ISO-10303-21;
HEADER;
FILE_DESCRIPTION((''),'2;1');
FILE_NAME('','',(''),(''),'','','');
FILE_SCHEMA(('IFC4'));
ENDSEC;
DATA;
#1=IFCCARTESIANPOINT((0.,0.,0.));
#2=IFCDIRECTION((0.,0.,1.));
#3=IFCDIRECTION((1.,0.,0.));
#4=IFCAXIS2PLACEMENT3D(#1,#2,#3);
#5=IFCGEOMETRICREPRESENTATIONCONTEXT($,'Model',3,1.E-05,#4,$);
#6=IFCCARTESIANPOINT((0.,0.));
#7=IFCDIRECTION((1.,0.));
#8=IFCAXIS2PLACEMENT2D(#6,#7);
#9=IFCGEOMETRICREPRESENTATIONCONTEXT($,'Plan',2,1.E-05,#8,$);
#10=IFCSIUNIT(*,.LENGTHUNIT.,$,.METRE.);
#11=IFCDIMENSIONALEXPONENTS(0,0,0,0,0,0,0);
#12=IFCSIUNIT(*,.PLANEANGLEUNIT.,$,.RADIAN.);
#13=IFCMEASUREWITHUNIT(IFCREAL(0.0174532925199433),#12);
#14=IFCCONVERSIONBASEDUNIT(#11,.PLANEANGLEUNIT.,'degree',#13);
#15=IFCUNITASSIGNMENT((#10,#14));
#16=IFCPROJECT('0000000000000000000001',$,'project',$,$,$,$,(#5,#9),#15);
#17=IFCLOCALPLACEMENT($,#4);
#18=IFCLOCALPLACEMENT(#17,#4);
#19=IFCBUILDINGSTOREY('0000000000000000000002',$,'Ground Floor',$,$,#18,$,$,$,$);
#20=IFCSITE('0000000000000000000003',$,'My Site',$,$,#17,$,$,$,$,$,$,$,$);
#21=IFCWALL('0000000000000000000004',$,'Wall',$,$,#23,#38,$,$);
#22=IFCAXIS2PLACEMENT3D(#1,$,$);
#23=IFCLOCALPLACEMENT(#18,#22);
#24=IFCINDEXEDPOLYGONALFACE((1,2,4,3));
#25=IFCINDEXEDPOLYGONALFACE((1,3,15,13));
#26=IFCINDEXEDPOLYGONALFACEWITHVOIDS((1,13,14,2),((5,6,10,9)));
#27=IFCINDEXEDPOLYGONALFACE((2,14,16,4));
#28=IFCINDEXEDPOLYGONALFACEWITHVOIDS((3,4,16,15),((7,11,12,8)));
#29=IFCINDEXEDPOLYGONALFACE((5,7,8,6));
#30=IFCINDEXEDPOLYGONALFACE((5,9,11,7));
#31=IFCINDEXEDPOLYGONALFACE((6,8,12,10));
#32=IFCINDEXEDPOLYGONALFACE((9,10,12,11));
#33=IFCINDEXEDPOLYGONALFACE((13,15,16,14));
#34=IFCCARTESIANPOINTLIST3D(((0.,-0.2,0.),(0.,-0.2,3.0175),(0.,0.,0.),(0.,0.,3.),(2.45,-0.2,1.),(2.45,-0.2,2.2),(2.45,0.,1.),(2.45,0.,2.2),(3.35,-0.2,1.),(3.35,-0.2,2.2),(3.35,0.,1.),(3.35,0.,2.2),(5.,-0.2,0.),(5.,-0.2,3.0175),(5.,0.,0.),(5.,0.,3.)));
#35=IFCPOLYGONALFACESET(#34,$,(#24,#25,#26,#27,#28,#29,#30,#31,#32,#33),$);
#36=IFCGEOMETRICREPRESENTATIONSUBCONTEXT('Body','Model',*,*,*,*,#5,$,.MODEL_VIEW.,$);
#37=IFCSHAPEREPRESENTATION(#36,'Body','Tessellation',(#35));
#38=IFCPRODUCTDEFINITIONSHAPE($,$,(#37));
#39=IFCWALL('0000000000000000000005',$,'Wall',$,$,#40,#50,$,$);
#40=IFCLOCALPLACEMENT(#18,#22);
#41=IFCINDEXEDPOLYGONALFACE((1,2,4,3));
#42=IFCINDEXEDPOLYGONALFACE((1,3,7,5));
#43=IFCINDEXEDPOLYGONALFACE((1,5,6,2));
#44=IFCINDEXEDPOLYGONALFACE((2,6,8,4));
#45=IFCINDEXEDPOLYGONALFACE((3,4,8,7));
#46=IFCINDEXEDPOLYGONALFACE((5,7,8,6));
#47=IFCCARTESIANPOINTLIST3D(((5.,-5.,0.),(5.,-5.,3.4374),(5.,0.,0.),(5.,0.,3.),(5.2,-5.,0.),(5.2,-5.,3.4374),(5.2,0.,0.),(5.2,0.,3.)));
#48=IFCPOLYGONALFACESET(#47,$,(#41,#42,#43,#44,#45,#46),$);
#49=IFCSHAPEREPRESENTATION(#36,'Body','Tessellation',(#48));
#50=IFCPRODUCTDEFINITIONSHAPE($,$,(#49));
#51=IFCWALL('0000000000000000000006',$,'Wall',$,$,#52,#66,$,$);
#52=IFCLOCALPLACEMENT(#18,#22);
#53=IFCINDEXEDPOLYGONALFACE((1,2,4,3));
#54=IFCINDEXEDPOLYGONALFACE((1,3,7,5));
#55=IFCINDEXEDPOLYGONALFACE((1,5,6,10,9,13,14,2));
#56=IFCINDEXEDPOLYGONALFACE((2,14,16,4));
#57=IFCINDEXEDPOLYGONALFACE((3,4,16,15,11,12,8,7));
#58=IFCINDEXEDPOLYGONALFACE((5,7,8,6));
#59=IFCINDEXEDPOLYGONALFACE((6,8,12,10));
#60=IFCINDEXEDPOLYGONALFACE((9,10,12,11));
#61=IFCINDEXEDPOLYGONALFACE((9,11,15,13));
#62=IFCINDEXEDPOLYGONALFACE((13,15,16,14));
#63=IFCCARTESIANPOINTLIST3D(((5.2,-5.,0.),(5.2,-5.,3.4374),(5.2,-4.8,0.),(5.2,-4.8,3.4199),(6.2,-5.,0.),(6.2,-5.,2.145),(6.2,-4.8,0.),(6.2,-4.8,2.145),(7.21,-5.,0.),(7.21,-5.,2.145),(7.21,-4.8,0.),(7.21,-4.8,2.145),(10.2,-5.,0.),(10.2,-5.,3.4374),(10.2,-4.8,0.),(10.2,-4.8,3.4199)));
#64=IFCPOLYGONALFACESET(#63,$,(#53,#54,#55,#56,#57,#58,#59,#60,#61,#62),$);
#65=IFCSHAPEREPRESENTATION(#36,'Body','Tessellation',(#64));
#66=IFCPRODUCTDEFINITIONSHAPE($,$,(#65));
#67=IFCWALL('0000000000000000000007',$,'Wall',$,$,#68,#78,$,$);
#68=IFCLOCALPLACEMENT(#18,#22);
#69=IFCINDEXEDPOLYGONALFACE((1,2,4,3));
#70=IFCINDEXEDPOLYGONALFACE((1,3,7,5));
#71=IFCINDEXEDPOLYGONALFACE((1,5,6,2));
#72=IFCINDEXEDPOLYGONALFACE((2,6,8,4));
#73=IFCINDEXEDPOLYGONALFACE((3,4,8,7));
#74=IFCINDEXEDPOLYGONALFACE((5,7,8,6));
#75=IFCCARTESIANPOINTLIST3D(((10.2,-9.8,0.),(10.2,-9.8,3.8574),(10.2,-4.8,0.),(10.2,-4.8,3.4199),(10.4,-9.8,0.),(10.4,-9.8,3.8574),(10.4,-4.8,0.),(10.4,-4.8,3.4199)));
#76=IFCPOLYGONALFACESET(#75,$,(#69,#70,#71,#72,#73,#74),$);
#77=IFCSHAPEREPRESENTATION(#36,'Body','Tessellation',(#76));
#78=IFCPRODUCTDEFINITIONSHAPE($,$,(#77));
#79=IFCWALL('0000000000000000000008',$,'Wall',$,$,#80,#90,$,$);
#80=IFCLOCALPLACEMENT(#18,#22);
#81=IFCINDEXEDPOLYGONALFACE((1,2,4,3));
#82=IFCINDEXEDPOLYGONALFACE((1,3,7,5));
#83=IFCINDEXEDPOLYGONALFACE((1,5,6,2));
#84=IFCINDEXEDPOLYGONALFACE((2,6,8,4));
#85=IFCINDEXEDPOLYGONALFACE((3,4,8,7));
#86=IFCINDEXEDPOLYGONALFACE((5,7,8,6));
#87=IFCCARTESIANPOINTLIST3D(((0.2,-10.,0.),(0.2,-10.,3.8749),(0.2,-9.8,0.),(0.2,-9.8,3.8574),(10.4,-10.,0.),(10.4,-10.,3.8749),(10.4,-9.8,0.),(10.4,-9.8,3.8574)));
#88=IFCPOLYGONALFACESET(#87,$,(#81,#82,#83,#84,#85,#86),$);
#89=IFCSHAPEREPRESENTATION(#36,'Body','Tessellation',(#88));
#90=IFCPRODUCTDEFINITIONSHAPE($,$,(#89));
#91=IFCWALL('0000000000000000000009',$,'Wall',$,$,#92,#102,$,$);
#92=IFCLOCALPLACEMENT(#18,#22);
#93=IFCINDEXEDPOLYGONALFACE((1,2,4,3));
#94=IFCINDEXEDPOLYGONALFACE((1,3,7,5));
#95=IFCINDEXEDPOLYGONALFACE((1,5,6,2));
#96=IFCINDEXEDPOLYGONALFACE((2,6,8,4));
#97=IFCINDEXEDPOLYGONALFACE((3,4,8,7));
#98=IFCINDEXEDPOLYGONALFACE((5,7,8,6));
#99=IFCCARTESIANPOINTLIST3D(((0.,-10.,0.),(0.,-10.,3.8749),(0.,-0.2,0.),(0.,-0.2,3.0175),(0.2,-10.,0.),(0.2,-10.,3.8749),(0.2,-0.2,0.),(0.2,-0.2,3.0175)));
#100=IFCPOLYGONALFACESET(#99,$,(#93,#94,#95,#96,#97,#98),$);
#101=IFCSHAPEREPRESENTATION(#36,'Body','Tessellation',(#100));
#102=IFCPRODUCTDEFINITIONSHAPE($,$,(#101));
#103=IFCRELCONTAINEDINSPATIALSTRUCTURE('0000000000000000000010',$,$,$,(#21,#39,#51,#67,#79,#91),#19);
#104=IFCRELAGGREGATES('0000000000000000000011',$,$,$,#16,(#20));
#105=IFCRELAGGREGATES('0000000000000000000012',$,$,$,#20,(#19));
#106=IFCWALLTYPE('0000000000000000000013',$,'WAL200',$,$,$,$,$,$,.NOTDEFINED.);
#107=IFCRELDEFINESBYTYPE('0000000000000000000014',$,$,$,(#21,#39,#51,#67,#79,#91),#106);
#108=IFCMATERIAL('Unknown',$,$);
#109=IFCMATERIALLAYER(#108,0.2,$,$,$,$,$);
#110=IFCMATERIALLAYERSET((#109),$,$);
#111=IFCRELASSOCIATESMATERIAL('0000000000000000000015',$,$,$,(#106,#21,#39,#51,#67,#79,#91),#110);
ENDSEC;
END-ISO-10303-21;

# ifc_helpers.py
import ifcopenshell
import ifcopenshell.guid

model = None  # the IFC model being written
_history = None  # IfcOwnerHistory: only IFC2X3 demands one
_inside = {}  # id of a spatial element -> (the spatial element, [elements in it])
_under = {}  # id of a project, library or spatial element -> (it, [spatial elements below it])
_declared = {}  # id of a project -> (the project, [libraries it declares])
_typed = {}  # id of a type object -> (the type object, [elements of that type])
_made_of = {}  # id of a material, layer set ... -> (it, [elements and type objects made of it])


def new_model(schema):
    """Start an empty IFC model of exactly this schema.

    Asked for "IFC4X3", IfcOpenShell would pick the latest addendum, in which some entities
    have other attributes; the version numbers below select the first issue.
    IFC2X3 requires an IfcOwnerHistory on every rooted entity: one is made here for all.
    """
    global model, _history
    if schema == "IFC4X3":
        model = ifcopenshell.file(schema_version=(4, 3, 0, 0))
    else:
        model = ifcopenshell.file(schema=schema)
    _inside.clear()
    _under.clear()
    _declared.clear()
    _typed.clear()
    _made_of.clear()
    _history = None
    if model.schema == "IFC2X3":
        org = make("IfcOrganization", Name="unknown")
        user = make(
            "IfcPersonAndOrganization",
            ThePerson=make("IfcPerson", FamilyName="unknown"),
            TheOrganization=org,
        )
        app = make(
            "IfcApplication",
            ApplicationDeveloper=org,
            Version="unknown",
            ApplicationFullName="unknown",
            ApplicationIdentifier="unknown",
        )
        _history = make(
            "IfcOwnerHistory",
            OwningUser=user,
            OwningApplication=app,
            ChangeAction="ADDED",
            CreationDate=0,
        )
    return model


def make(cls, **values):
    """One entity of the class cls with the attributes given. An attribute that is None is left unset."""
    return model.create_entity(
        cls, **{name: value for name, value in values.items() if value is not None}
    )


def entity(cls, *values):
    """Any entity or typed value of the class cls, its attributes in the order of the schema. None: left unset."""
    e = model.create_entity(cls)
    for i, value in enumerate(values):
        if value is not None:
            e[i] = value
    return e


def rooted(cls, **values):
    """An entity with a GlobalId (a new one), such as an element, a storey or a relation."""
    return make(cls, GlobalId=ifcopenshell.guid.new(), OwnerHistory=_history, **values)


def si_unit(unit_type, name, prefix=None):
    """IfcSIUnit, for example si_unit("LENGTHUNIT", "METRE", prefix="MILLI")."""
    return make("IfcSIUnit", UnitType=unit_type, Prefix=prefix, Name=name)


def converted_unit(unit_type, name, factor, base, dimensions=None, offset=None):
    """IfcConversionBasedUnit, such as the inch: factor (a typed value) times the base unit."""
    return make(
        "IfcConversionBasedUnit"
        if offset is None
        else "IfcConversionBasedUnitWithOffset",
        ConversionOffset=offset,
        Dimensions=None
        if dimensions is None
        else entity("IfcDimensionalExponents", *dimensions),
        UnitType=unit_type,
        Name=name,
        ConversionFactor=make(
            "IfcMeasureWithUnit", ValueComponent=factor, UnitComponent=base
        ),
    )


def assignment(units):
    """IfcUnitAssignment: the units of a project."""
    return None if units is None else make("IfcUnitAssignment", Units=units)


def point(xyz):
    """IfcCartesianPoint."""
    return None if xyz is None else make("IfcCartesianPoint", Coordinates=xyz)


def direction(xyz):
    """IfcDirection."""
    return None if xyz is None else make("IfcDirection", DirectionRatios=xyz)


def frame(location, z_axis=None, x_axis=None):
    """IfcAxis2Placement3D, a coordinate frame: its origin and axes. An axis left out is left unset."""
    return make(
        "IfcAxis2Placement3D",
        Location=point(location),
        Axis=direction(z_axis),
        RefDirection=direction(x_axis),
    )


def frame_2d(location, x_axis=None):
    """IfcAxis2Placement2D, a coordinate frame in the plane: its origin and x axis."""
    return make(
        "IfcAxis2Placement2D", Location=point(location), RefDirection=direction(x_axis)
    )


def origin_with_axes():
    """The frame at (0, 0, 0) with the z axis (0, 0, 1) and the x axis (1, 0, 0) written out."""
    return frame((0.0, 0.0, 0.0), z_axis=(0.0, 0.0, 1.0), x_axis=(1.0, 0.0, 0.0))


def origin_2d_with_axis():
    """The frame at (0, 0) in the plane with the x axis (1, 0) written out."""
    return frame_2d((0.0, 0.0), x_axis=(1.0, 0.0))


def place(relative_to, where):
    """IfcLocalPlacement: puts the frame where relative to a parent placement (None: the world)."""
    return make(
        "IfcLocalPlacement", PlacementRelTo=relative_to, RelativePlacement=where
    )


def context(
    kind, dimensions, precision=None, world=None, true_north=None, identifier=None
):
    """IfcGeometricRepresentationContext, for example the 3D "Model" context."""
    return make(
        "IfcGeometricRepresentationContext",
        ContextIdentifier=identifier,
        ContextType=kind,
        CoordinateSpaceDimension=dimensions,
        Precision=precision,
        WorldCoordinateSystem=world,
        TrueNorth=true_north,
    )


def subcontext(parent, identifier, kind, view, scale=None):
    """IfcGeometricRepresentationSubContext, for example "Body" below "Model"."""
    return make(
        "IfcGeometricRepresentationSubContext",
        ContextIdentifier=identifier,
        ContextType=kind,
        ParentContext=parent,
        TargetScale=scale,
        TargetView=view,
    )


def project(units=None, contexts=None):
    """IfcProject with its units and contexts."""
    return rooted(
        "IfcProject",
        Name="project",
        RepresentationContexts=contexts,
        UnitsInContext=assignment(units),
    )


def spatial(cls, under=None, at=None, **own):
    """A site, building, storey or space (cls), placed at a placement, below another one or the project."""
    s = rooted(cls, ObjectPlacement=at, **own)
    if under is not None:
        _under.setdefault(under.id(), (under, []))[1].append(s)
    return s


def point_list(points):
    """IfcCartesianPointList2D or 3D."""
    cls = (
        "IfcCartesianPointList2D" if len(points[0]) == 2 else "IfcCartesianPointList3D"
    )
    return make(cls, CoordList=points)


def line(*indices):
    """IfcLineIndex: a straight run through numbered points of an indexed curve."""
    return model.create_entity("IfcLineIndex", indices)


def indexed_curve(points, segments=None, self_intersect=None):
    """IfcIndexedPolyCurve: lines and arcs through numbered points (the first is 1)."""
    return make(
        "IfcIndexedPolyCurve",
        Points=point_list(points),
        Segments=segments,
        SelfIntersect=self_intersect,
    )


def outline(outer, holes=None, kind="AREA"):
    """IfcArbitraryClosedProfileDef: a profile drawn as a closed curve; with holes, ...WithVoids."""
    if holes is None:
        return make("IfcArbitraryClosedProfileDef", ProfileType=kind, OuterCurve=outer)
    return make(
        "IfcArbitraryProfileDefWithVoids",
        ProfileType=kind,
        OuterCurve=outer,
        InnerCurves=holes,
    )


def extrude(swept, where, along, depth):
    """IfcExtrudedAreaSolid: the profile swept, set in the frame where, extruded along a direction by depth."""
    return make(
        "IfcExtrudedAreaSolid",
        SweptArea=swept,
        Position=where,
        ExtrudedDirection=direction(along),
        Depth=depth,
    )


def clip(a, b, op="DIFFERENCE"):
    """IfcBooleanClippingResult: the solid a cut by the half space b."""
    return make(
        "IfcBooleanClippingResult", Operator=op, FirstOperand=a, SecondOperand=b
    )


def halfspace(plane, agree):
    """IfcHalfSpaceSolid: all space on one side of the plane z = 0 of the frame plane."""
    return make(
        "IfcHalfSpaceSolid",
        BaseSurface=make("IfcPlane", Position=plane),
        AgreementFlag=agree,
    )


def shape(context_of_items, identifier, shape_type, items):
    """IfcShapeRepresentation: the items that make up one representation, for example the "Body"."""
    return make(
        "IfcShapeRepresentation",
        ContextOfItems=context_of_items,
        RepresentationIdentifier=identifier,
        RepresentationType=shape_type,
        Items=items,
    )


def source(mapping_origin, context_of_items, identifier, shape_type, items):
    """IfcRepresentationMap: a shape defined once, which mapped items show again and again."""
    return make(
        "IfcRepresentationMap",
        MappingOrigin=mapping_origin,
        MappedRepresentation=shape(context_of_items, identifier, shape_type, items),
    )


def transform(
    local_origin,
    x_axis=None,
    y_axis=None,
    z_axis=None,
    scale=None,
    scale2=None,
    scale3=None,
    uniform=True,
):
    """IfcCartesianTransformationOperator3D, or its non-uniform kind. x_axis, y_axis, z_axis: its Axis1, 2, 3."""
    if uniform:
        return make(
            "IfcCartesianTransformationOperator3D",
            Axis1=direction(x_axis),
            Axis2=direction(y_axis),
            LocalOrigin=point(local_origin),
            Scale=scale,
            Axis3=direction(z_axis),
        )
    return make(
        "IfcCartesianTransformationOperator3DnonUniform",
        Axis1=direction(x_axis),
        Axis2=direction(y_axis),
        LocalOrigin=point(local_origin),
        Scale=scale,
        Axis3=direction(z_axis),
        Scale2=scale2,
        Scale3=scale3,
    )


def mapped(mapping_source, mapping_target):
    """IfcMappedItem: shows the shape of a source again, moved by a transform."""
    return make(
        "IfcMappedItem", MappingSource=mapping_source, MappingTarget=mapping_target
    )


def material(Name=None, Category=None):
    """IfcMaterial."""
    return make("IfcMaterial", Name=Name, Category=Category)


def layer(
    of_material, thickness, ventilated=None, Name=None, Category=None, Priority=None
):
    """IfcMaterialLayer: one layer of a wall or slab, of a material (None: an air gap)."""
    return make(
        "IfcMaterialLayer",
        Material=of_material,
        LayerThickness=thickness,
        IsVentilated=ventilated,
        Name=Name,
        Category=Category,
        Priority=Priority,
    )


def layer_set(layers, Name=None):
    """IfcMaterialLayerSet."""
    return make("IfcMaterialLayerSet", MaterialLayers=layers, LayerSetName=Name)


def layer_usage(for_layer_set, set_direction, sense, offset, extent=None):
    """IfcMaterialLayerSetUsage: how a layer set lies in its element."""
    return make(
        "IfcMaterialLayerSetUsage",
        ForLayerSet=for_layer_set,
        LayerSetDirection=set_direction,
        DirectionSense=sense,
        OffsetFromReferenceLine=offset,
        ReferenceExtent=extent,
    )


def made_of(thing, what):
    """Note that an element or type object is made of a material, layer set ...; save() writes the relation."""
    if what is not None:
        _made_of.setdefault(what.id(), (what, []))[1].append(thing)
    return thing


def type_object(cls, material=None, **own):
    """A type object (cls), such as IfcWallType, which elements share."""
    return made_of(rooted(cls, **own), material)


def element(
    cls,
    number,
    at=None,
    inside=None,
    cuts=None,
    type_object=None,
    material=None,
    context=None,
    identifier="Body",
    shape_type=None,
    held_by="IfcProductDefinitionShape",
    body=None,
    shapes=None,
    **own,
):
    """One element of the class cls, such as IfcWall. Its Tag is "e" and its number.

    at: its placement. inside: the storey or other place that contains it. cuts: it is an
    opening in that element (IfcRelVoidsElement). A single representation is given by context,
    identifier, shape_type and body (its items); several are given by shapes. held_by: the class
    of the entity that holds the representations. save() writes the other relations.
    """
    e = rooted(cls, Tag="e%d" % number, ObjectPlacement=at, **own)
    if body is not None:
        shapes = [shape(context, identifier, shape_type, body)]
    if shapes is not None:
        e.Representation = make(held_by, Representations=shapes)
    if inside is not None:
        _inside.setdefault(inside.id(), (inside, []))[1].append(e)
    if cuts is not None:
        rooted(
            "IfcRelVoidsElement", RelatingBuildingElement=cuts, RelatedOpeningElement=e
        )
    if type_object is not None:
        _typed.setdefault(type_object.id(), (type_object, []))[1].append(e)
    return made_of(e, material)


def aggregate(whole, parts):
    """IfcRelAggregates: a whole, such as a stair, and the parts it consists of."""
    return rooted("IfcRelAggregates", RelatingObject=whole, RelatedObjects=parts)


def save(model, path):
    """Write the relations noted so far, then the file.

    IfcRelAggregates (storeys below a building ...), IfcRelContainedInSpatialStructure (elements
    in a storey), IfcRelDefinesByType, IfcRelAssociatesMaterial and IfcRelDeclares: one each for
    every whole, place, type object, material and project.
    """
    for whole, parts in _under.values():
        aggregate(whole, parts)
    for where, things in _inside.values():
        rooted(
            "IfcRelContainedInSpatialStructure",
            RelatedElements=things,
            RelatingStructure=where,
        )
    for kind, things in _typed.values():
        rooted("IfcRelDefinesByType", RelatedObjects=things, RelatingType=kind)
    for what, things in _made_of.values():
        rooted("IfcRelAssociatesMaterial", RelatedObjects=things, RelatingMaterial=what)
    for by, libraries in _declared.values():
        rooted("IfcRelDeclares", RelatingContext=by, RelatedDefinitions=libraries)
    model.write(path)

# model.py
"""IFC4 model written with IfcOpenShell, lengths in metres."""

from ifc_helpers import new_model, entity, si_unit, converted_unit, frame, origin_with_axes, origin_2d_with_axis, place, context, subcontext, project, spatial, line, indexed_curve, outline, extrude, clip, halfspace, source, transform, mapped, material, layer, layer_set, layer_usage, type_object, element, save


model = new_model("IFC4")

# Units and contexts
model_context = context("Model", 3, precision=1e-05, world=origin_with_axes())
plan_context = context("Plan", 2, precision=1e-05, world=origin_2d_with_axis())
body_context = subcontext(model_context, "Body", "Model", "MODEL_VIEW")
ifc_project = project(units=[si_unit("LENGTHUNIT", "METRE"), converted_unit("PLANEANGLEUNIT", "degree", entity("IfcReal", 0.0174532925199433), si_unit("PLANEANGLEUNIT", "RADIAN"), dimensions=[0, 0, 0, 0, 0, 0, 0])], contexts=[model_context, plan_context])

# Site, storey
site_placement = place(None, origin_with_axes())
site = spatial("IfcSite", under=ifc_project, at=site_placement, Name="My Site")
storey_placement = place(site_placement, origin_with_axes())
storey = spatial("IfcBuildingStorey", under=site, at=storey_placement, Name="Ground Floor")

# Shared definitions
ifc_material = material(Name="Unknown")

# Wall, opening
ifc_layer_1 = layer(ifc_material, 0.2)
ifc_layer_set_1 = layer_set([ifc_layer_1])
ifc_layer_usage_1 = layer_usage(ifc_layer_set_1, "AXIS2", "POSITIVE", 0.0)
wall_type = type_object("IfcWallType", Name="WAL200", PredefinedType="NOTDEFINED", material=ifc_layer_set_1)
wall_1_placement = place(storey_placement, frame((5.0, 0.0, 0.0), z_axis=(0.0, 0.0, 1.0), x_axis=(-1.0, 0.0, 0.0)))
wall_1 = element("IfcWall", 1, at=wall_1_placement, inside=storey, type_object=wall_type, material=ifc_layer_usage_1, Name="Wall", context=body_context, shape_type="Clipping", body=[
    clip(extrude(outline(indexed_curve([(0.0, 0.0), (0.0, 0.2), (5.0, 0.2), (5.0, 0.0), (0.0, 0.0)], self_intersect=False)), origin_with_axes(), (0.0, 0.0, 1.0), 3.0175), halfspace(frame((0.0, 0.2, 3.0175), z_axis=(0.0, -0.087156, 0.996195), x_axis=(1.0, 0.0, 0.0)), False)),
])
shared_shape_1 = source(origin_with_axes(), body_context, "Body", "SweptSolid", [
    extrude(outline(indexed_curve([(0.0, 0.0), (0.9, 0.0), (0.9, 1.2), (0.0, 1.2)], segments=[line(1, 2, 3, 4, 1)])), frame((0.0, -0.6, 0.0), z_axis=(0.0, -1.0, 0.0), x_axis=(1.0, 0.0, 0.0)), (0.0, 0.0, -1.0), 1.2),
])
opening_1_placement = place(wall_1_placement, frame((1.65, 0.0, 1.0), z_axis=(0.0, 0.0, 1.0), x_axis=(1.0, 0.0, 0.0)))
element("IfcOpeningElement", 2, at=opening_1_placement, cuts=wall_1, PredefinedType="OPENING", context=body_context, shape_type="MappedRepresentation", body=[
    mapped(shared_shape_1, transform((0.0, 0.0, 0.0), x_axis=(1.0, 0.0, 0.0), y_axis=(0.0, 1.0, 0.0), z_axis=(0.0, 0.0, 1.0), scale=1.0)),
])

# Wall
ifc_layer_usage_2 = layer_usage(ifc_layer_set_1, "AXIS2", "POSITIVE", 0.0)
wall_2_placement = place(storey_placement, frame((5.0, 0.0, 0.0), z_axis=(0.0, 0.0, 1.0), x_axis=(-0.000001, -1.0, 0.0)))
element("IfcWall", 3, at=wall_2_placement, inside=storey, type_object=wall_type, material=ifc_layer_usage_2, Name="Wall", context=body_context, shape_type="Clipping", body=[
    clip(extrude(outline(indexed_curve([(0.0, 0.0), (0.0, 0.2), (5.0, 0.2), (5.0, 0.0), (0.0, 0.0)], self_intersect=False)), origin_with_axes(), (0.0, 0.0, 1.0), 3.4374), halfspace(frame((5.0, 0.0, 3.4374), z_axis=(-0.087156, 0.0, 0.996195), x_axis=(0.0, -1.0, 0.0)), False)),
])

# Wall, opening
ifc_layer_usage_3 = layer_usage(ifc_layer_set_1, "AXIS2", "POSITIVE", 0.0)
wall_3_placement = place(storey_placement, frame((5.2, -5.0, 0.0), z_axis=(0.0, 0.0, 1.0), x_axis=(1.0, -0.000001, 0.0)))
wall_3 = element("IfcWall", 4, at=wall_3_placement, inside=storey, type_object=wall_type, material=ifc_layer_usage_3, Name="Wall", context=body_context, shape_type="Clipping", body=[
    clip(extrude(outline(indexed_curve([(0.0, 0.0), (0.0, 0.2), (5.0, 0.2), (5.0, 0.0), (0.0, 0.0)], self_intersect=False)), origin_with_axes(), (0.0, 0.0, 1.0), 3.4374), halfspace(frame((5.0, 0.0, 3.4374), z_axis=(0.0, 0.087156, 0.996195), x_axis=(-1.0, -0.000001, 0.0)), False)),
])
shared_shape_2 = source(origin_with_axes(), body_context, "Body", "SweptSolid", [
    extrude(outline(indexed_curve([(0.0, 0.0), (1.01, 0.0), (1.01, 2.145), (0.0, 2.145)], segments=[line(1, 2, 3, 4, 1)])), frame((0.0, -0.6, 0.0), z_axis=(0.0, -1.0, 0.0), x_axis=(1.0, 0.0, 0.0)), (0.0, 0.0, -1.0), 1.2),
])
opening_2_placement = place(wall_3_placement, frame((1.0, 0.0, 0.0), z_axis=(0.0, 0.0, 1.0), x_axis=(1.0, 0.0, 0.0)))
element("IfcOpeningElement", 5, at=opening_2_placement, cuts=wall_3, PredefinedType="OPENING", context=body_context, shape_type="MappedRepresentation", body=[
    mapped(shared_shape_2, transform((0.0, 0.0, 0.0), x_axis=(1.0, 0.0, 0.0), y_axis=(0.0, 1.0, 0.0), z_axis=(0.0, 0.0, 1.0), scale=1.0)),
])

# Walls
ifc_layer_usage_4 = layer_usage(ifc_layer_set_1, "AXIS2", "POSITIVE", 0.0)
wall_4_placement = place(storey_placement, frame((10.2, -4.8, 0.0), z_axis=(0.0, 0.0, 1.0), x_axis=(-0.000001, -1.0, 0.0)))
element("IfcWall", 6, at=wall_4_placement, inside=storey, type_object=wall_type, material=ifc_layer_usage_4, Name="Wall", context=body_context, shape_type="Clipping", body=[
    clip(extrude(outline(indexed_curve([(0.0, 0.0), (0.0, 0.2), (5.0, 0.2), (5.0, 0.0), (0.0, 0.0)], self_intersect=False)), origin_with_axes(), (0.0, 0.0, 1.0), 3.8574), halfspace(frame((5.0, 0.0, 3.8574), z_axis=(-0.087156, 0.0, 0.996195), x_axis=(0.0, -1.0, 0.0)), False)),
])
ifc_layer_usage_5 = layer_usage(ifc_layer_set_1, "AXIS2", "POSITIVE", 0.0)
wall_5_placement = place(storey_placement, frame((10.4, -9.8, 0.0), z_axis=(0.0, 0.0, 1.0), x_axis=(-1.0, 0.000001, 0.0)))
element("IfcWall", 7, at=wall_5_placement, inside=storey, type_object=wall_type, material=ifc_layer_usage_5, Name="Wall", context=body_context, shape_type="Clipping", body=[
    clip(extrude(outline(indexed_curve([(0.0, 0.0), (0.0, 0.2), (10.2, 0.2), (10.2, 0.0), (0.0, 0.0)], self_intersect=False)), origin_with_axes(), (0.0, 0.0, 1.0), 3.8749), halfspace(frame((0.0, 0.2, 3.8749), z_axis=(0.0, -0.087156, 0.996195), x_axis=(1.0, 0.000001, 0.0)), False)),
])
ifc_layer_usage_6 = layer_usage(ifc_layer_set_1, "AXIS2", "POSITIVE", 0.0)
wall_6_placement = place(storey_placement, frame((0.0, -0.2, 0.0), z_axis=(0.0, 0.0, 1.0), x_axis=(-0.000001, -1.0, 0.0)))
element("IfcWall", 8, at=wall_6_placement, inside=storey, type_object=wall_type, material=ifc_layer_usage_6, Name="Wall", context=body_context, shape_type="Clipping", body=[
    clip(extrude(outline(indexed_curve([(0.0, 0.0), (0.0, 0.2), (9.8, 0.2), (9.8, 0.0), (0.0, 0.0)], self_intersect=False)), origin_with_axes(), (0.0, 0.0, 1.0), 3.8749), halfspace(frame((9.8, 0.0, 3.8749), z_axis=(-0.087156, 0.0, 0.996195), x_axis=(0.0, -1.0, 0.0)), False)),
])

save(model, "model.ifc")
